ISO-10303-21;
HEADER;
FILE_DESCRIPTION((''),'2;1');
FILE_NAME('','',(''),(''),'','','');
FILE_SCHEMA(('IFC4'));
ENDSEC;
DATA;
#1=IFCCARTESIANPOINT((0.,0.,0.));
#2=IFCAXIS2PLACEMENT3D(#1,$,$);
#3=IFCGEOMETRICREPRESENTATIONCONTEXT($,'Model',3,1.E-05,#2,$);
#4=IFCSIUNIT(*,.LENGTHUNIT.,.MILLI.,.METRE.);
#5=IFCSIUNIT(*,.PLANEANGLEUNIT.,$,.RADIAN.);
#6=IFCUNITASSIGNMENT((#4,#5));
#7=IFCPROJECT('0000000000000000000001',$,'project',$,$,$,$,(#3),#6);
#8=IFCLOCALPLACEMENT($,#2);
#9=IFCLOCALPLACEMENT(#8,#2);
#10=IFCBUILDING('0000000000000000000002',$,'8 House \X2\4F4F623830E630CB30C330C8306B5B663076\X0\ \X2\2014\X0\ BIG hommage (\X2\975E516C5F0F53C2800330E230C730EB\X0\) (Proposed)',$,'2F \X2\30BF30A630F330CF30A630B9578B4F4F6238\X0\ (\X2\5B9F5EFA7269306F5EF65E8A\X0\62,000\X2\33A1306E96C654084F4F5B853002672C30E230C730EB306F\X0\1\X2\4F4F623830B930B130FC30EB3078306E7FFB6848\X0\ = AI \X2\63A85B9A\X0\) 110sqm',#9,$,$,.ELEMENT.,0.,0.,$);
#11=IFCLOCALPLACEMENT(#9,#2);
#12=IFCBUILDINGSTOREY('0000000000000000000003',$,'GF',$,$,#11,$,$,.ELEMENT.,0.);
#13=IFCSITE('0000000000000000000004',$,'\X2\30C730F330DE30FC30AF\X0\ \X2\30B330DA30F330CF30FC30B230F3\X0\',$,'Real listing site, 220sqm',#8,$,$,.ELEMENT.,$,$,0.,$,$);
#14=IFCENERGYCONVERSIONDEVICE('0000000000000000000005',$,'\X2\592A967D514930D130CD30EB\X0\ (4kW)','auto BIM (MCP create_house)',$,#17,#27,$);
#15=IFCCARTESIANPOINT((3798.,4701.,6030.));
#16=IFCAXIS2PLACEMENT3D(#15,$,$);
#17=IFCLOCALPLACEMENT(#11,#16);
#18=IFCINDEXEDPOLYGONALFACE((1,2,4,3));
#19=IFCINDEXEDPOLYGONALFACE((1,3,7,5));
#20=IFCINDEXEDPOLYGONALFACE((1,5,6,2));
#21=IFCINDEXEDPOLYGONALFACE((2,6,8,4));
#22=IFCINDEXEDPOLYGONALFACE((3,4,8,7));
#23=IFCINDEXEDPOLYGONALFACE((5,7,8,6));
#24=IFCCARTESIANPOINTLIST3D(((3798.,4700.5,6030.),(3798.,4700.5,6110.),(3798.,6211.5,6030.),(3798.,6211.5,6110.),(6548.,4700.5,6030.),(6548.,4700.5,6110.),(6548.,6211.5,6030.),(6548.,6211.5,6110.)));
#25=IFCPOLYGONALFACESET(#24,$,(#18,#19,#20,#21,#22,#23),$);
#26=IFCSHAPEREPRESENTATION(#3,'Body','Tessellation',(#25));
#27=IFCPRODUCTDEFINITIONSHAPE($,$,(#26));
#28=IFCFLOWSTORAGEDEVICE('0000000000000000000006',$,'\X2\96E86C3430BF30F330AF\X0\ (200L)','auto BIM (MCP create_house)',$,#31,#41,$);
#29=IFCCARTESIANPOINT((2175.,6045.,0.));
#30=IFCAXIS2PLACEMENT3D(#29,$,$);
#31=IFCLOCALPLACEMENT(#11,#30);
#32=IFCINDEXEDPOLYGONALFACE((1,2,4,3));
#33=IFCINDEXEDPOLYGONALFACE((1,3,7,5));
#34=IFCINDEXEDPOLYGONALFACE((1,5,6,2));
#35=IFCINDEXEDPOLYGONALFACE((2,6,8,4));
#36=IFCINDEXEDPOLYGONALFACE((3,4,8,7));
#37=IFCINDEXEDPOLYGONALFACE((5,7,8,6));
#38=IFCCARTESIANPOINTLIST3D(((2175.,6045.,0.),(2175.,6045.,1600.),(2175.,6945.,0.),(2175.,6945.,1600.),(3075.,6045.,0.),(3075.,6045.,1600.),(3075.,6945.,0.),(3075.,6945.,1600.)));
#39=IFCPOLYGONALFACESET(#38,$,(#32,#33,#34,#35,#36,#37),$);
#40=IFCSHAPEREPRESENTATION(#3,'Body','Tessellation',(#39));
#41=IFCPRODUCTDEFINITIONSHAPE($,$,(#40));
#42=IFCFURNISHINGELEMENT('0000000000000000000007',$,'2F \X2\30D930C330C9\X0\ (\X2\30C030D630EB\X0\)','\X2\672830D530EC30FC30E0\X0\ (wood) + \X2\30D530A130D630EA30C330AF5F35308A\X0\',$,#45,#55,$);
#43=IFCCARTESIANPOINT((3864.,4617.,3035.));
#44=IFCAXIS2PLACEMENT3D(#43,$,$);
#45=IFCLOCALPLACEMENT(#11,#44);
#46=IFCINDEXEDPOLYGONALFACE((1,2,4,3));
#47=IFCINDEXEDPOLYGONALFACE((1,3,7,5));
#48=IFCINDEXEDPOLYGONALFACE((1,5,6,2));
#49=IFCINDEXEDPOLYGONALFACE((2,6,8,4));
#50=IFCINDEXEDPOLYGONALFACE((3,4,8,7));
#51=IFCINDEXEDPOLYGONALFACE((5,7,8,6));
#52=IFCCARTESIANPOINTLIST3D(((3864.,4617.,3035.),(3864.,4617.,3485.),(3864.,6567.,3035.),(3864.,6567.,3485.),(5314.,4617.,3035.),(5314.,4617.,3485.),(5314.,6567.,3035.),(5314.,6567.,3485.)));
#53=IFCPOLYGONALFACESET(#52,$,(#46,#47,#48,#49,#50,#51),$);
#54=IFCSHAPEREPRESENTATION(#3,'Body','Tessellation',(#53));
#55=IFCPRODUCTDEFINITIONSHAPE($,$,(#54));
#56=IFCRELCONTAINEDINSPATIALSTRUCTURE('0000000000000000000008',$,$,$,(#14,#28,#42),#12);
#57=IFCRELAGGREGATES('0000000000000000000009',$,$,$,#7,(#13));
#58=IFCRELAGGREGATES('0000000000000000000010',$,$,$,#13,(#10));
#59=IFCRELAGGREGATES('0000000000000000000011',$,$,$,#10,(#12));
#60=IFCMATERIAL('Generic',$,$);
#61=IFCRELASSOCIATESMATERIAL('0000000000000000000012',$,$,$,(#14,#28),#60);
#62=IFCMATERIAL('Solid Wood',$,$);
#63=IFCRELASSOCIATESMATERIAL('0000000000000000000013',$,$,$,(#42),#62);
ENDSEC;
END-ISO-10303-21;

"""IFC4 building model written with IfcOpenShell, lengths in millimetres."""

from ifc_helpers import new_model, si_unit, frame, frame_2d, origin, place, context, project, spatial, rectangle, extrude, material, element, save


model = new_model("IFC4")

# Units and contexts
model_context = context("Model", 3, precision=1e-05, world=origin())
ifc_project = project(units=[si_unit("LENGTHUNIT", "METRE", prefix="MILLI"), si_unit("PLANEANGLEUNIT", "RADIAN")], contexts=[model_context])

# Site, building, storey
site_placement = place(None, origin())
site = spatial("IfcSite", under=ifc_project, at=site_placement, Name="デンマーク コペンハーゲン", ObjectType="Real listing site, 220sqm", CompositionType="ELEMENT", RefElevation=0.0)
building_placement = place(site_placement, origin())
building = spatial("IfcBuilding", under=site, at=building_placement, Name="8 House 住戸ユニットに学ぶ — BIG hommage (非公式参考モデル) (Proposed)", ObjectType="2F タウンハウス型住戸 (実建物は延床62,000㎡の集合住宅。本モデルは1住戸スケールへの翻案 = AI 推定) 110sqm", CompositionType="ELEMENT", ElevationOfRefHeight=0.0, ElevationOfTerrain=0.0)
storey_placement = place(building_placement, origin())
storey = spatial("IfcBuildingStorey", under=building, at=storey_placement, Name="GF", CompositionType="ELEMENT", Elevation=0.0)

# Shared definitions
ifc_material_1 = material(Name="Solid Wood")

# Shared definitions
ifc_material_2 = material(Name="Generic")

# Energy conversion device
energy_conversion_device_placement = place(storey_placement, frame((3798.0, 4701.0, 6030.0)))
element("IfcEnergyConversionDevice", 1, at=energy_conversion_device_placement, inside=storey, material=ifc_material_2, Name="太陽光パネル (4kW)", Description="auto BIM (MCP create_house)", context=model_context, shape_type="SweptSolid", body=[
    extrude(rectangle(XDim=2750.0, YDim=1511.0, at=frame_2d((1375.0, 755.0))), frame((3798.0, 4701.0, 6030.0)), (0.0, 0.0, 1.0), 80.0),
])

# Flow storage device
flow_storage_device_placement = place(storey_placement, frame((2175.0, 6045.0, 0.0)))
element("IfcFlowStorageDevice", 2, at=flow_storage_device_placement, inside=storey, material=ifc_material_2, Name="雨水タンク (200L)", Description="auto BIM (MCP create_house)", context=model_context, shape_type="SweptSolid", body=[
    extrude(rectangle(XDim=900.0, YDim=900.0, at=frame_2d((450.0, 450.0))), frame((2175.0, 6045.0, 0.0)), (0.0, 0.0, 1.0), 1600.0),
])

# Furnishing element
furnishing_placement = place(storey_placement, frame((3864.0, 4617.0, 3035.0)))
element("IfcFurnishingElement", 3, at=furnishing_placement, inside=storey, material=ifc_material_1, Name="2F ベッド (ダブル)", Description="木フレーム (wood) + ファブリック張り", context=model_context, shape_type="SweptSolid", body=[
    extrude(rectangle(XDim=1450.0, YDim=1950.0, at=frame_2d((725.0, 975.0))), frame((3864.0, 4617.0, 3035.0)), (0.0, 0.0, 1.0), 450.0),
])

save(model, "model.ifc")
